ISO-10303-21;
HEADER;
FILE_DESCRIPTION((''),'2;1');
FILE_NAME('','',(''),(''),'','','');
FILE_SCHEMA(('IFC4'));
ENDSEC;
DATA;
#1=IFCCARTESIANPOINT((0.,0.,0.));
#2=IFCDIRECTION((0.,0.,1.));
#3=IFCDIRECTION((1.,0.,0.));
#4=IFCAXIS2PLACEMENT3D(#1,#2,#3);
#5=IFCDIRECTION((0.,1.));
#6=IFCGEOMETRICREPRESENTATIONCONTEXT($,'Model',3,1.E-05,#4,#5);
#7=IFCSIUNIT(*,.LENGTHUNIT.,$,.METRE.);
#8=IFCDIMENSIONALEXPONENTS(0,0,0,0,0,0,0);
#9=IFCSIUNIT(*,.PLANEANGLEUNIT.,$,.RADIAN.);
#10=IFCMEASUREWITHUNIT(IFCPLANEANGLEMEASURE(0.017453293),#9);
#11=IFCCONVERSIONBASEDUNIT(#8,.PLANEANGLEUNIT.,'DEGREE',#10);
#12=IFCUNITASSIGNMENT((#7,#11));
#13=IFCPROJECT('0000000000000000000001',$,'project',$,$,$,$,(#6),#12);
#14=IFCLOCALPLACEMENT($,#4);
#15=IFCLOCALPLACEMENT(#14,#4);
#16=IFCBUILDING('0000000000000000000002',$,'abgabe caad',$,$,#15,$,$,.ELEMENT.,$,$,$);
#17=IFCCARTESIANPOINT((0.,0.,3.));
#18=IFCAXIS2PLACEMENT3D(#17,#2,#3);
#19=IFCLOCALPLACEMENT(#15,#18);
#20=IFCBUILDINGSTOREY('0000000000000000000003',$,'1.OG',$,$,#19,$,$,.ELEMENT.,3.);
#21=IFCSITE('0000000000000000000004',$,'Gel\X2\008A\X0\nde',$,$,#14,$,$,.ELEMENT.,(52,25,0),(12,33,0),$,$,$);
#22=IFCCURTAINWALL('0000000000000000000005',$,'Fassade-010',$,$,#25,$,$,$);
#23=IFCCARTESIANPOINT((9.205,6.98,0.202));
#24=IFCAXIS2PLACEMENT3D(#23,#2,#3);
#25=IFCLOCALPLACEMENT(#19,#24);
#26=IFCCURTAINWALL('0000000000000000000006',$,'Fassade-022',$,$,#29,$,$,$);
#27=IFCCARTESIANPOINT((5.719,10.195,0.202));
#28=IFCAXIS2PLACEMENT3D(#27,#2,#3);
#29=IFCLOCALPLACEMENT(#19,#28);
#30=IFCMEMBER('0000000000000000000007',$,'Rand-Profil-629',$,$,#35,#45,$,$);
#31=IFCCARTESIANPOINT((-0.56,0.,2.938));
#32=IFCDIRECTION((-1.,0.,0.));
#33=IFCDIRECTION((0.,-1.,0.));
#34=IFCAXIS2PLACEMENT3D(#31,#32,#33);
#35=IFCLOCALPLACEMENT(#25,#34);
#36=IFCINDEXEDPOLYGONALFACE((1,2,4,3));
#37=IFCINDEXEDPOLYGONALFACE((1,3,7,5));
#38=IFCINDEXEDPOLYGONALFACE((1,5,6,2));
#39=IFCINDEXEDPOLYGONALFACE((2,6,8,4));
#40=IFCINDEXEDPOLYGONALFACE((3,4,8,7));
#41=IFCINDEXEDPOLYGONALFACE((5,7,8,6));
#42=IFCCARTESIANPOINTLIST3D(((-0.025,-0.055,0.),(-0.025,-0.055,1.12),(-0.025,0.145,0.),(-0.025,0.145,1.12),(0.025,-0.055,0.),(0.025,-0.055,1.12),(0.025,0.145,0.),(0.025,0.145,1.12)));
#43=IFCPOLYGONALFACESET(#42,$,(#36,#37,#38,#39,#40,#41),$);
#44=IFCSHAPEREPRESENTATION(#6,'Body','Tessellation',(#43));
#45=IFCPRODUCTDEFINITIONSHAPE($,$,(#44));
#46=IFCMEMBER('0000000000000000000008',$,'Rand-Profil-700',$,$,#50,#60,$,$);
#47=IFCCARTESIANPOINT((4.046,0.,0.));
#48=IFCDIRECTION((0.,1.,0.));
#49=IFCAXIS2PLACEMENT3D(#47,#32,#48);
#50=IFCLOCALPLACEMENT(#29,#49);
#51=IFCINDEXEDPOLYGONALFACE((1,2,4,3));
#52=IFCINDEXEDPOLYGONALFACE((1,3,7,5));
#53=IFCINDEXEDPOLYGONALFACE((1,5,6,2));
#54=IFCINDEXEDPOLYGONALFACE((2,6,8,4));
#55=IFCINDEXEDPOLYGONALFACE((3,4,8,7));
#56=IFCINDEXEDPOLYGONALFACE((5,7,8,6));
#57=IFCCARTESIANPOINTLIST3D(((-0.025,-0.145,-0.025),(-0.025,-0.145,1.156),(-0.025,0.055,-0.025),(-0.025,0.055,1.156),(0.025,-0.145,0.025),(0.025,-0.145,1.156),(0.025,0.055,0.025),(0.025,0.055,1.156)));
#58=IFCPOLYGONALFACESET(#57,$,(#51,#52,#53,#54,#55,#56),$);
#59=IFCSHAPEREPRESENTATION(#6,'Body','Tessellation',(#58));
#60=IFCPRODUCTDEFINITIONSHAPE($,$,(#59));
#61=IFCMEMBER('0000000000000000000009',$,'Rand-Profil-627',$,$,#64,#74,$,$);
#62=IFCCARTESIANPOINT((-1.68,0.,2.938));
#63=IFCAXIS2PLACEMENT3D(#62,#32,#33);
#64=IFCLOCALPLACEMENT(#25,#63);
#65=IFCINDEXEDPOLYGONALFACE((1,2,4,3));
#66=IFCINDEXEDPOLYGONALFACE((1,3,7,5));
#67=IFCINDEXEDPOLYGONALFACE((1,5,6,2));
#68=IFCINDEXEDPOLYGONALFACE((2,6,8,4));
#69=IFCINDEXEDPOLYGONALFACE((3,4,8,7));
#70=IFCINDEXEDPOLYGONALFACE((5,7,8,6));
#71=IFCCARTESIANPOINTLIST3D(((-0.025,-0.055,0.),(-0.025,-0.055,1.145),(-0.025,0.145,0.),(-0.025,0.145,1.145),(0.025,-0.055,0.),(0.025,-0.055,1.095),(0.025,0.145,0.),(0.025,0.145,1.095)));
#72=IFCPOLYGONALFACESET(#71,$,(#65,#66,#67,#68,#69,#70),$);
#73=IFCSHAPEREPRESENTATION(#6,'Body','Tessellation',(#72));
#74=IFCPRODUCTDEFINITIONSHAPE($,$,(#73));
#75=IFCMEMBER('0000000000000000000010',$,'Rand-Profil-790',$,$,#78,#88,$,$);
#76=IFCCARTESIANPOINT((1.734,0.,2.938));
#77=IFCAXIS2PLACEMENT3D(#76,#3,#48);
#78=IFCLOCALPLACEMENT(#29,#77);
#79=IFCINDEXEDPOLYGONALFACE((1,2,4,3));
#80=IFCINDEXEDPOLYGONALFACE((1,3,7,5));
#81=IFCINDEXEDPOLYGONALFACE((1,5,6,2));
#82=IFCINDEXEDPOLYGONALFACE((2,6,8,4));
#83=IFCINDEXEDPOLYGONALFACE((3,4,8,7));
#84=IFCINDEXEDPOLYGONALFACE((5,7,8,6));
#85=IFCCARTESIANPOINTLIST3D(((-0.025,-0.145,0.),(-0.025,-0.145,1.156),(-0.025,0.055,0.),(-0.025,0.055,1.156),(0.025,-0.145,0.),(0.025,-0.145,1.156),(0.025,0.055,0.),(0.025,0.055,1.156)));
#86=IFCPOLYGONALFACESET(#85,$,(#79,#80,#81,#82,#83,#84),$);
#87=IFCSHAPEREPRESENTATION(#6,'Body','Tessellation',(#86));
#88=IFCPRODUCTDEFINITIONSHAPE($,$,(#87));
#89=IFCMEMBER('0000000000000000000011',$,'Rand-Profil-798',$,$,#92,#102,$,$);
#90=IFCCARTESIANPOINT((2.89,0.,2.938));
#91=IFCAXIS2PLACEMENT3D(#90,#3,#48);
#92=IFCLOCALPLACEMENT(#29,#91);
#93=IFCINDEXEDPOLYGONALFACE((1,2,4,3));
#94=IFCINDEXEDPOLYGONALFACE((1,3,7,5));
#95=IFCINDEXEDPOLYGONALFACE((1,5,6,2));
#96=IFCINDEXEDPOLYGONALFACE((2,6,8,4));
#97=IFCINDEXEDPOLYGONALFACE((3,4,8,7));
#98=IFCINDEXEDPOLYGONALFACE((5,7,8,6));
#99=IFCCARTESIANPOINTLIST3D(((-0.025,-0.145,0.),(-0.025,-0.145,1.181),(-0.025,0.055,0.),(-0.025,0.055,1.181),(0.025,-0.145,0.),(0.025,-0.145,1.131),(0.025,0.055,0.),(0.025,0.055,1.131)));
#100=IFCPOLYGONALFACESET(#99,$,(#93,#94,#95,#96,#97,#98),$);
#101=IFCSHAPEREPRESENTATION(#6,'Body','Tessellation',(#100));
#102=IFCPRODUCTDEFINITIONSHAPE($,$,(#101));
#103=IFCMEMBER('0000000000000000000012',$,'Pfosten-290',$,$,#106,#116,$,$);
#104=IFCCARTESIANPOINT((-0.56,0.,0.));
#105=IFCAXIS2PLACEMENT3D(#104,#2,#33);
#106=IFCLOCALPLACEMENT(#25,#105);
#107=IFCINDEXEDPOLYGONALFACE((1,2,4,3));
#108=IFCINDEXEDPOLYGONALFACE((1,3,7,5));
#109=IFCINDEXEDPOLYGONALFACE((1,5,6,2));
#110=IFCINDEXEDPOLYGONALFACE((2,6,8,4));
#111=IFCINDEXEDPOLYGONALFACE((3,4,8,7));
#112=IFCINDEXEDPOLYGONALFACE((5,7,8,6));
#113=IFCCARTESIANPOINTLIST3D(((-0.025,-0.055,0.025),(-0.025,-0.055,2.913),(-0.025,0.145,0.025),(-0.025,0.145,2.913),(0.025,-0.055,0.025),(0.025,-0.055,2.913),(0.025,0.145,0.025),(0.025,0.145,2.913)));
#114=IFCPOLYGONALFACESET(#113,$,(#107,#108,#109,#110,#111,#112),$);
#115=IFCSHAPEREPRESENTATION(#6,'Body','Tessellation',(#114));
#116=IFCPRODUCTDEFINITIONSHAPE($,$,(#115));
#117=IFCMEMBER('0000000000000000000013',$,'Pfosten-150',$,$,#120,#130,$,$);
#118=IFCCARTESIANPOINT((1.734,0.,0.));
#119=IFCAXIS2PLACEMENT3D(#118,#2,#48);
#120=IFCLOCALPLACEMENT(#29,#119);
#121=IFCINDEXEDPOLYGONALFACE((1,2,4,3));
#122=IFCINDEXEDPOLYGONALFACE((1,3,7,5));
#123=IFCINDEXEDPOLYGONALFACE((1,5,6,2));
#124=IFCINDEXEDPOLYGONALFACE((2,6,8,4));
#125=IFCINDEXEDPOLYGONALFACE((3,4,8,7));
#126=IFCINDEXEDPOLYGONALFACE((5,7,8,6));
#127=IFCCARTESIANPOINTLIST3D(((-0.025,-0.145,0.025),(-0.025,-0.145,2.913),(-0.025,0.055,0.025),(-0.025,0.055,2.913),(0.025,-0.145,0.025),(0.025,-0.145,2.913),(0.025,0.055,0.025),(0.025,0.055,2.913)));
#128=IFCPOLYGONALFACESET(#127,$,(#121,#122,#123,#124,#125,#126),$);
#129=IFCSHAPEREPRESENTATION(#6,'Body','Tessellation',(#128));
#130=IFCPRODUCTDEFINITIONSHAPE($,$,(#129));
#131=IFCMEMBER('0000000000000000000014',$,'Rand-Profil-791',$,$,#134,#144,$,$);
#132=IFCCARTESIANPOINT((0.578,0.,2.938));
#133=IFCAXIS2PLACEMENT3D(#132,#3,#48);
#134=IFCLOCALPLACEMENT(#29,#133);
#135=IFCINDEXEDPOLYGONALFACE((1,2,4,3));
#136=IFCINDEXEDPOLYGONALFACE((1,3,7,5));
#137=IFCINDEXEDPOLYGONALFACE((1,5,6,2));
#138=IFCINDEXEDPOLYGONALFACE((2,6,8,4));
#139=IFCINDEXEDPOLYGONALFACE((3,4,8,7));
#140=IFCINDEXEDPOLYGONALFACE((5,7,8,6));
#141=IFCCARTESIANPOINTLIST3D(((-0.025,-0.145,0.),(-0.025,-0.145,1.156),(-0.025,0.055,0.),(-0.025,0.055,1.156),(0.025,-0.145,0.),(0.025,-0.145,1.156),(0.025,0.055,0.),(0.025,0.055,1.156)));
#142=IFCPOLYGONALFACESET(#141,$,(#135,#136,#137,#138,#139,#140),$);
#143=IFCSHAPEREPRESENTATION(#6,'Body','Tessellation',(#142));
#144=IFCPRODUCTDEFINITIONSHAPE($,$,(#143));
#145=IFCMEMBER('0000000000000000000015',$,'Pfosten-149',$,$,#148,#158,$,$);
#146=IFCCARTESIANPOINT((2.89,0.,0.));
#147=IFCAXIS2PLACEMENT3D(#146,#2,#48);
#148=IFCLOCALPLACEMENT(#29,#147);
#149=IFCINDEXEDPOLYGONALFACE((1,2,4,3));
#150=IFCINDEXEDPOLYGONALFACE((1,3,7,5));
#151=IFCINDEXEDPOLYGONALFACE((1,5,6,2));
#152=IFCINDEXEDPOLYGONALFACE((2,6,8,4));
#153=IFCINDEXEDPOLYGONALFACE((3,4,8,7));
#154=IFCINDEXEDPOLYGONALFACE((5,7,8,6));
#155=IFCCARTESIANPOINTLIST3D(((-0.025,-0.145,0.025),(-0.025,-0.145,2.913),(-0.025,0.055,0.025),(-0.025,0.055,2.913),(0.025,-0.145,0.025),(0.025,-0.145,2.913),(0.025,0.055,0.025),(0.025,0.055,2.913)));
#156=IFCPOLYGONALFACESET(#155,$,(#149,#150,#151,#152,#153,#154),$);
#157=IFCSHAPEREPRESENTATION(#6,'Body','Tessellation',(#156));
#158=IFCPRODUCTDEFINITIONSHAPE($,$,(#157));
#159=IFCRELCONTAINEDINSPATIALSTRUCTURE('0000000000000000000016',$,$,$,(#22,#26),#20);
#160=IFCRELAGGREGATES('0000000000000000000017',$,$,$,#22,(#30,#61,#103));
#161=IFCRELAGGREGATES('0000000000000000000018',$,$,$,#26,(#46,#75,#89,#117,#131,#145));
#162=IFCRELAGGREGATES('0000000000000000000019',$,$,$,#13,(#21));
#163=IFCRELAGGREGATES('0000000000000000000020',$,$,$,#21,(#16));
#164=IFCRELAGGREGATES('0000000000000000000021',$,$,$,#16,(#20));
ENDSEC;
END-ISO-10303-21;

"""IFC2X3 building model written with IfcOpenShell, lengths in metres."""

from ifc_helpers import new_model, entity, si_unit, converted_unit, direction, frame, origin_with_axes, place, context, project, spatial, polyline, outline, extrude, clip, halfspace, element, aggregate, save


model = new_model("IFC2X3")

# Units and contexts
model_context = context("Model", 3, precision=1e-05, world=origin_with_axes(), true_north=direction((0.0, 1.0)))
ifc_project = project(units=[si_unit("LENGTHUNIT", "METRE"), converted_unit("PLANEANGLEUNIT", "DEGREE", entity("IfcPlaneAngleMeasure", 0.017453293), si_unit("PLANEANGLEUNIT", "RADIAN"), dimensions=[0, 0, 0, 0, 0, 0, 0])], contexts=[model_context])

# Site, building, storey
site_placement = place(None, origin_with_axes())
site = spatial("IfcSite", under=ifc_project, at=site_placement, Name="Gel\u008ande", CompositionType="ELEMENT", RefLatitude=(52, 25, 0), RefLongitude=(12, 33, 0))
building_placement = place(site_placement, origin_with_axes())
building = spatial("IfcBuilding", under=site, at=building_placement, Name="abgabe caad", CompositionType="ELEMENT")
storey_placement = place(building_placement, frame((0.0, 0.0, 3.0), z_axis=(0.0, 0.0, 1.0), x_axis=(1.0, 0.0, 0.0)))
storey = spatial("IfcBuildingStorey", under=building, at=storey_placement, Name="1.OG", CompositionType="ELEMENT", Elevation=3.0)

# Curtain walls
curtain_wall_1_placement = place(storey_placement, frame((9.205, 6.98, 0.202), z_axis=(0.0, 0.0, 1.0), x_axis=(1.0, 0.0, 0.0)))
curtain_wall_1 = element("IfcCurtainWall", 1, at=curtain_wall_1_placement, inside=storey, Name="Fassade-010")
curtain_wall_2_placement = place(storey_placement, frame((5.719, 10.195, 0.202), z_axis=(0.0, 0.0, 1.0), x_axis=(1.0, 0.0, 0.0)))
curtain_wall_2 = element("IfcCurtainWall", 2, at=curtain_wall_2_placement, inside=storey, Name="Fassade-022")

# Members
member_1_placement = place(curtain_wall_1_placement, frame((-0.56, 0.0, 2.938), z_axis=(-1.0, 0.0, 0.0), x_axis=(0.0, -1.0, 0.0)))
member_1 = element("IfcMember", 3, at=member_1_placement, Name="Rand-Profil-629", context=model_context, shape_type="SweptSolid", body=[
    extrude(outline(polyline([(-0.025, -0.145), (0.025, -0.145), (0.025, 0.055), (-0.025, 0.055), (-0.025, -0.145)])), frame((0.0, 0.0, 0.0), z_axis=(0.0, 0.0, 1.0), x_axis=(-1.0, 0.0, 0.0)), (0.0, 0.0, 1.0), 1.12),
])
member_2_placement = place(curtain_wall_2_placement, frame((4.046, 0.0, 0.0), z_axis=(-1.0, 0.0, 0.0), x_axis=(0.0, 1.0, 0.0)))
member_2 = element("IfcMember", 4, at=member_2_placement, Name="Rand-Profil-700", context=model_context, shape_type="Clipping", body=[
    clip(extrude(outline(polyline([(0.025, -0.145), (0.025, 0.055), (-0.025, 0.055), (-0.025, -0.145), (0.025, -0.145)])), frame((0.0, 0.0, -0.025), z_axis=(0.0, 0.0, 1.0), x_axis=(1.0, 0.0, 0.0)), (0.0, 0.0, 1.0), 1.181), halfspace(frame((0.0, 0.0, 0.0), z_axis=(-0.707107, 0.0, 0.707107), x_axis=(-0.707107, 0.0, -0.707107)), True)),
])
member_3_placement = place(curtain_wall_1_placement, frame((-1.68, 0.0, 2.938), z_axis=(-1.0, 0.0, 0.0), x_axis=(0.0, -1.0, 0.0)))
member_3 = element("IfcMember", 5, at=member_3_placement, Name="Rand-Profil-627", context=model_context, shape_type="Clipping", body=[
    clip(extrude(outline(polyline([(-0.025, -0.145), (0.025, -0.145), (0.025, 0.055), (-0.025, 0.055), (-0.025, -0.145)])), frame((0.0, 0.0, 0.0), z_axis=(0.0, 0.0, 1.0), x_axis=(-1.0, 0.0, 0.0)), (0.0, 0.0, 1.0), 1.145), halfspace(frame((0.56, 0.0, 0.56), z_axis=(-0.707107, 0.0, -0.707107), x_axis=(0.707107, 0.0, -0.707107)), True)),
])
member_4_placement = place(curtain_wall_2_placement, frame((1.734, 0.0, 2.938), z_axis=(1.0, 0.0, 0.0), x_axis=(0.0, 1.0, 0.0)))
member_4 = element("IfcMember", 6, at=member_4_placement, Name="Rand-Profil-790", context=model_context, shape_type="SweptSolid", body=[
    extrude(outline(polyline([(-0.025, 0.145), (-0.025, -0.055), (0.025, -0.055), (0.025, 0.145), (-0.025, 0.145)])), frame((0.0, 0.0, 0.0), z_axis=(0.0, 0.0, 1.0), x_axis=(-1.0, 0.0, 0.0)), (0.0, 0.0, 1.0), 1.156),
])
member_5_placement = place(curtain_wall_2_placement, frame((2.89, 0.0, 2.938), z_axis=(1.0, 0.0, 0.0), x_axis=(0.0, 1.0, 0.0)))
member_5 = element("IfcMember", 7, at=member_5_placement, Name="Rand-Profil-798", context=model_context, shape_type="Clipping", body=[
    clip(extrude(outline(polyline([(-0.025, 0.145), (-0.025, -0.055), (0.025, -0.055), (0.025, 0.145), (-0.025, 0.145)])), frame((0.0, 0.0, 0.0), z_axis=(0.0, 0.0, 1.0), x_axis=(-1.0, 0.0, 0.0)), (0.0, 0.0, 1.0), 1.181), halfspace(frame((0.578, 0.0, 0.578), z_axis=(-0.707107, 0.0, -0.707107), x_axis=(0.707107, 0.0, -0.707107)), True)),
])
member_6_placement = place(curtain_wall_1_placement, frame((-0.56, 0.0, 0.0), z_axis=(0.0, 0.0, 1.0), x_axis=(0.0, -1.0, 0.0)))
member_6 = element("IfcMember", 8, at=member_6_placement, Name="Pfosten-290", context=model_context, shape_type="SweptSolid", body=[
    extrude(outline(polyline([(0.145, -0.025), (0.145, 0.025), (-0.055, 0.025), (-0.055, -0.025), (0.145, -0.025)])), frame((0.0, 0.0, 0.025), z_axis=(0.0, 0.0, 1.0), x_axis=(0.0, 1.0, 0.0)), (0.0, 0.0, 1.0), 2.888),
])
member_7_placement = place(curtain_wall_2_placement, frame((1.734, 0.0, 0.0), z_axis=(0.0, 0.0, 1.0), x_axis=(0.0, 1.0, 0.0)))
member_7 = element("IfcMember", 9, at=member_7_placement, Name="Pfosten-150", context=model_context, shape_type="SweptSolid", body=[
    extrude(outline(polyline([(0.145, 0.025), (-0.055, 0.025), (-0.055, -0.025), (0.145, -0.025), (0.145, 0.025)])), frame((0.0, 0.0, 0.025), z_axis=(0.0, 0.0, 1.0), x_axis=(0.0, -1.0, 0.0)), (0.0, 0.0, 1.0), 2.888),
])
member_8_placement = place(curtain_wall_2_placement, frame((0.578, 0.0, 2.938), z_axis=(1.0, 0.0, 0.0), x_axis=(0.0, 1.0, 0.0)))
member_8 = element("IfcMember", 10, at=member_8_placement, Name="Rand-Profil-791", context=model_context, shape_type="SweptSolid", body=[
    extrude(outline(polyline([(-0.025, 0.145), (-0.025, -0.055), (0.025, -0.055), (0.025, 0.145), (-0.025, 0.145)])), frame((0.0, 0.0, 0.0), z_axis=(0.0, 0.0, 1.0), x_axis=(-1.0, 0.0, 0.0)), (0.0, 0.0, 1.0), 1.156),
])
member_9_placement = place(curtain_wall_2_placement, frame((2.89, 0.0, 0.0), z_axis=(0.0, 0.0, 1.0), x_axis=(0.0, 1.0, 0.0)))
member_9 = element("IfcMember", 11, at=member_9_placement, Name="Pfosten-149", context=model_context, shape_type="SweptSolid", body=[
    extrude(outline(polyline([(0.145, 0.025), (-0.055, 0.025), (-0.055, -0.025), (0.145, -0.025), (0.145, 0.025)])), frame((0.0, 0.0, 0.025), z_axis=(0.0, 0.0, 1.0), x_axis=(0.0, -1.0, 0.0)), (0.0, 0.0, 1.0), 2.888),
])

aggregate(curtain_wall_1, [member_1, member_3, member_6])
aggregate(curtain_wall_2, [member_2, member_4, member_5, member_7, member_8, member_9])

save(model, "model.ifc")
